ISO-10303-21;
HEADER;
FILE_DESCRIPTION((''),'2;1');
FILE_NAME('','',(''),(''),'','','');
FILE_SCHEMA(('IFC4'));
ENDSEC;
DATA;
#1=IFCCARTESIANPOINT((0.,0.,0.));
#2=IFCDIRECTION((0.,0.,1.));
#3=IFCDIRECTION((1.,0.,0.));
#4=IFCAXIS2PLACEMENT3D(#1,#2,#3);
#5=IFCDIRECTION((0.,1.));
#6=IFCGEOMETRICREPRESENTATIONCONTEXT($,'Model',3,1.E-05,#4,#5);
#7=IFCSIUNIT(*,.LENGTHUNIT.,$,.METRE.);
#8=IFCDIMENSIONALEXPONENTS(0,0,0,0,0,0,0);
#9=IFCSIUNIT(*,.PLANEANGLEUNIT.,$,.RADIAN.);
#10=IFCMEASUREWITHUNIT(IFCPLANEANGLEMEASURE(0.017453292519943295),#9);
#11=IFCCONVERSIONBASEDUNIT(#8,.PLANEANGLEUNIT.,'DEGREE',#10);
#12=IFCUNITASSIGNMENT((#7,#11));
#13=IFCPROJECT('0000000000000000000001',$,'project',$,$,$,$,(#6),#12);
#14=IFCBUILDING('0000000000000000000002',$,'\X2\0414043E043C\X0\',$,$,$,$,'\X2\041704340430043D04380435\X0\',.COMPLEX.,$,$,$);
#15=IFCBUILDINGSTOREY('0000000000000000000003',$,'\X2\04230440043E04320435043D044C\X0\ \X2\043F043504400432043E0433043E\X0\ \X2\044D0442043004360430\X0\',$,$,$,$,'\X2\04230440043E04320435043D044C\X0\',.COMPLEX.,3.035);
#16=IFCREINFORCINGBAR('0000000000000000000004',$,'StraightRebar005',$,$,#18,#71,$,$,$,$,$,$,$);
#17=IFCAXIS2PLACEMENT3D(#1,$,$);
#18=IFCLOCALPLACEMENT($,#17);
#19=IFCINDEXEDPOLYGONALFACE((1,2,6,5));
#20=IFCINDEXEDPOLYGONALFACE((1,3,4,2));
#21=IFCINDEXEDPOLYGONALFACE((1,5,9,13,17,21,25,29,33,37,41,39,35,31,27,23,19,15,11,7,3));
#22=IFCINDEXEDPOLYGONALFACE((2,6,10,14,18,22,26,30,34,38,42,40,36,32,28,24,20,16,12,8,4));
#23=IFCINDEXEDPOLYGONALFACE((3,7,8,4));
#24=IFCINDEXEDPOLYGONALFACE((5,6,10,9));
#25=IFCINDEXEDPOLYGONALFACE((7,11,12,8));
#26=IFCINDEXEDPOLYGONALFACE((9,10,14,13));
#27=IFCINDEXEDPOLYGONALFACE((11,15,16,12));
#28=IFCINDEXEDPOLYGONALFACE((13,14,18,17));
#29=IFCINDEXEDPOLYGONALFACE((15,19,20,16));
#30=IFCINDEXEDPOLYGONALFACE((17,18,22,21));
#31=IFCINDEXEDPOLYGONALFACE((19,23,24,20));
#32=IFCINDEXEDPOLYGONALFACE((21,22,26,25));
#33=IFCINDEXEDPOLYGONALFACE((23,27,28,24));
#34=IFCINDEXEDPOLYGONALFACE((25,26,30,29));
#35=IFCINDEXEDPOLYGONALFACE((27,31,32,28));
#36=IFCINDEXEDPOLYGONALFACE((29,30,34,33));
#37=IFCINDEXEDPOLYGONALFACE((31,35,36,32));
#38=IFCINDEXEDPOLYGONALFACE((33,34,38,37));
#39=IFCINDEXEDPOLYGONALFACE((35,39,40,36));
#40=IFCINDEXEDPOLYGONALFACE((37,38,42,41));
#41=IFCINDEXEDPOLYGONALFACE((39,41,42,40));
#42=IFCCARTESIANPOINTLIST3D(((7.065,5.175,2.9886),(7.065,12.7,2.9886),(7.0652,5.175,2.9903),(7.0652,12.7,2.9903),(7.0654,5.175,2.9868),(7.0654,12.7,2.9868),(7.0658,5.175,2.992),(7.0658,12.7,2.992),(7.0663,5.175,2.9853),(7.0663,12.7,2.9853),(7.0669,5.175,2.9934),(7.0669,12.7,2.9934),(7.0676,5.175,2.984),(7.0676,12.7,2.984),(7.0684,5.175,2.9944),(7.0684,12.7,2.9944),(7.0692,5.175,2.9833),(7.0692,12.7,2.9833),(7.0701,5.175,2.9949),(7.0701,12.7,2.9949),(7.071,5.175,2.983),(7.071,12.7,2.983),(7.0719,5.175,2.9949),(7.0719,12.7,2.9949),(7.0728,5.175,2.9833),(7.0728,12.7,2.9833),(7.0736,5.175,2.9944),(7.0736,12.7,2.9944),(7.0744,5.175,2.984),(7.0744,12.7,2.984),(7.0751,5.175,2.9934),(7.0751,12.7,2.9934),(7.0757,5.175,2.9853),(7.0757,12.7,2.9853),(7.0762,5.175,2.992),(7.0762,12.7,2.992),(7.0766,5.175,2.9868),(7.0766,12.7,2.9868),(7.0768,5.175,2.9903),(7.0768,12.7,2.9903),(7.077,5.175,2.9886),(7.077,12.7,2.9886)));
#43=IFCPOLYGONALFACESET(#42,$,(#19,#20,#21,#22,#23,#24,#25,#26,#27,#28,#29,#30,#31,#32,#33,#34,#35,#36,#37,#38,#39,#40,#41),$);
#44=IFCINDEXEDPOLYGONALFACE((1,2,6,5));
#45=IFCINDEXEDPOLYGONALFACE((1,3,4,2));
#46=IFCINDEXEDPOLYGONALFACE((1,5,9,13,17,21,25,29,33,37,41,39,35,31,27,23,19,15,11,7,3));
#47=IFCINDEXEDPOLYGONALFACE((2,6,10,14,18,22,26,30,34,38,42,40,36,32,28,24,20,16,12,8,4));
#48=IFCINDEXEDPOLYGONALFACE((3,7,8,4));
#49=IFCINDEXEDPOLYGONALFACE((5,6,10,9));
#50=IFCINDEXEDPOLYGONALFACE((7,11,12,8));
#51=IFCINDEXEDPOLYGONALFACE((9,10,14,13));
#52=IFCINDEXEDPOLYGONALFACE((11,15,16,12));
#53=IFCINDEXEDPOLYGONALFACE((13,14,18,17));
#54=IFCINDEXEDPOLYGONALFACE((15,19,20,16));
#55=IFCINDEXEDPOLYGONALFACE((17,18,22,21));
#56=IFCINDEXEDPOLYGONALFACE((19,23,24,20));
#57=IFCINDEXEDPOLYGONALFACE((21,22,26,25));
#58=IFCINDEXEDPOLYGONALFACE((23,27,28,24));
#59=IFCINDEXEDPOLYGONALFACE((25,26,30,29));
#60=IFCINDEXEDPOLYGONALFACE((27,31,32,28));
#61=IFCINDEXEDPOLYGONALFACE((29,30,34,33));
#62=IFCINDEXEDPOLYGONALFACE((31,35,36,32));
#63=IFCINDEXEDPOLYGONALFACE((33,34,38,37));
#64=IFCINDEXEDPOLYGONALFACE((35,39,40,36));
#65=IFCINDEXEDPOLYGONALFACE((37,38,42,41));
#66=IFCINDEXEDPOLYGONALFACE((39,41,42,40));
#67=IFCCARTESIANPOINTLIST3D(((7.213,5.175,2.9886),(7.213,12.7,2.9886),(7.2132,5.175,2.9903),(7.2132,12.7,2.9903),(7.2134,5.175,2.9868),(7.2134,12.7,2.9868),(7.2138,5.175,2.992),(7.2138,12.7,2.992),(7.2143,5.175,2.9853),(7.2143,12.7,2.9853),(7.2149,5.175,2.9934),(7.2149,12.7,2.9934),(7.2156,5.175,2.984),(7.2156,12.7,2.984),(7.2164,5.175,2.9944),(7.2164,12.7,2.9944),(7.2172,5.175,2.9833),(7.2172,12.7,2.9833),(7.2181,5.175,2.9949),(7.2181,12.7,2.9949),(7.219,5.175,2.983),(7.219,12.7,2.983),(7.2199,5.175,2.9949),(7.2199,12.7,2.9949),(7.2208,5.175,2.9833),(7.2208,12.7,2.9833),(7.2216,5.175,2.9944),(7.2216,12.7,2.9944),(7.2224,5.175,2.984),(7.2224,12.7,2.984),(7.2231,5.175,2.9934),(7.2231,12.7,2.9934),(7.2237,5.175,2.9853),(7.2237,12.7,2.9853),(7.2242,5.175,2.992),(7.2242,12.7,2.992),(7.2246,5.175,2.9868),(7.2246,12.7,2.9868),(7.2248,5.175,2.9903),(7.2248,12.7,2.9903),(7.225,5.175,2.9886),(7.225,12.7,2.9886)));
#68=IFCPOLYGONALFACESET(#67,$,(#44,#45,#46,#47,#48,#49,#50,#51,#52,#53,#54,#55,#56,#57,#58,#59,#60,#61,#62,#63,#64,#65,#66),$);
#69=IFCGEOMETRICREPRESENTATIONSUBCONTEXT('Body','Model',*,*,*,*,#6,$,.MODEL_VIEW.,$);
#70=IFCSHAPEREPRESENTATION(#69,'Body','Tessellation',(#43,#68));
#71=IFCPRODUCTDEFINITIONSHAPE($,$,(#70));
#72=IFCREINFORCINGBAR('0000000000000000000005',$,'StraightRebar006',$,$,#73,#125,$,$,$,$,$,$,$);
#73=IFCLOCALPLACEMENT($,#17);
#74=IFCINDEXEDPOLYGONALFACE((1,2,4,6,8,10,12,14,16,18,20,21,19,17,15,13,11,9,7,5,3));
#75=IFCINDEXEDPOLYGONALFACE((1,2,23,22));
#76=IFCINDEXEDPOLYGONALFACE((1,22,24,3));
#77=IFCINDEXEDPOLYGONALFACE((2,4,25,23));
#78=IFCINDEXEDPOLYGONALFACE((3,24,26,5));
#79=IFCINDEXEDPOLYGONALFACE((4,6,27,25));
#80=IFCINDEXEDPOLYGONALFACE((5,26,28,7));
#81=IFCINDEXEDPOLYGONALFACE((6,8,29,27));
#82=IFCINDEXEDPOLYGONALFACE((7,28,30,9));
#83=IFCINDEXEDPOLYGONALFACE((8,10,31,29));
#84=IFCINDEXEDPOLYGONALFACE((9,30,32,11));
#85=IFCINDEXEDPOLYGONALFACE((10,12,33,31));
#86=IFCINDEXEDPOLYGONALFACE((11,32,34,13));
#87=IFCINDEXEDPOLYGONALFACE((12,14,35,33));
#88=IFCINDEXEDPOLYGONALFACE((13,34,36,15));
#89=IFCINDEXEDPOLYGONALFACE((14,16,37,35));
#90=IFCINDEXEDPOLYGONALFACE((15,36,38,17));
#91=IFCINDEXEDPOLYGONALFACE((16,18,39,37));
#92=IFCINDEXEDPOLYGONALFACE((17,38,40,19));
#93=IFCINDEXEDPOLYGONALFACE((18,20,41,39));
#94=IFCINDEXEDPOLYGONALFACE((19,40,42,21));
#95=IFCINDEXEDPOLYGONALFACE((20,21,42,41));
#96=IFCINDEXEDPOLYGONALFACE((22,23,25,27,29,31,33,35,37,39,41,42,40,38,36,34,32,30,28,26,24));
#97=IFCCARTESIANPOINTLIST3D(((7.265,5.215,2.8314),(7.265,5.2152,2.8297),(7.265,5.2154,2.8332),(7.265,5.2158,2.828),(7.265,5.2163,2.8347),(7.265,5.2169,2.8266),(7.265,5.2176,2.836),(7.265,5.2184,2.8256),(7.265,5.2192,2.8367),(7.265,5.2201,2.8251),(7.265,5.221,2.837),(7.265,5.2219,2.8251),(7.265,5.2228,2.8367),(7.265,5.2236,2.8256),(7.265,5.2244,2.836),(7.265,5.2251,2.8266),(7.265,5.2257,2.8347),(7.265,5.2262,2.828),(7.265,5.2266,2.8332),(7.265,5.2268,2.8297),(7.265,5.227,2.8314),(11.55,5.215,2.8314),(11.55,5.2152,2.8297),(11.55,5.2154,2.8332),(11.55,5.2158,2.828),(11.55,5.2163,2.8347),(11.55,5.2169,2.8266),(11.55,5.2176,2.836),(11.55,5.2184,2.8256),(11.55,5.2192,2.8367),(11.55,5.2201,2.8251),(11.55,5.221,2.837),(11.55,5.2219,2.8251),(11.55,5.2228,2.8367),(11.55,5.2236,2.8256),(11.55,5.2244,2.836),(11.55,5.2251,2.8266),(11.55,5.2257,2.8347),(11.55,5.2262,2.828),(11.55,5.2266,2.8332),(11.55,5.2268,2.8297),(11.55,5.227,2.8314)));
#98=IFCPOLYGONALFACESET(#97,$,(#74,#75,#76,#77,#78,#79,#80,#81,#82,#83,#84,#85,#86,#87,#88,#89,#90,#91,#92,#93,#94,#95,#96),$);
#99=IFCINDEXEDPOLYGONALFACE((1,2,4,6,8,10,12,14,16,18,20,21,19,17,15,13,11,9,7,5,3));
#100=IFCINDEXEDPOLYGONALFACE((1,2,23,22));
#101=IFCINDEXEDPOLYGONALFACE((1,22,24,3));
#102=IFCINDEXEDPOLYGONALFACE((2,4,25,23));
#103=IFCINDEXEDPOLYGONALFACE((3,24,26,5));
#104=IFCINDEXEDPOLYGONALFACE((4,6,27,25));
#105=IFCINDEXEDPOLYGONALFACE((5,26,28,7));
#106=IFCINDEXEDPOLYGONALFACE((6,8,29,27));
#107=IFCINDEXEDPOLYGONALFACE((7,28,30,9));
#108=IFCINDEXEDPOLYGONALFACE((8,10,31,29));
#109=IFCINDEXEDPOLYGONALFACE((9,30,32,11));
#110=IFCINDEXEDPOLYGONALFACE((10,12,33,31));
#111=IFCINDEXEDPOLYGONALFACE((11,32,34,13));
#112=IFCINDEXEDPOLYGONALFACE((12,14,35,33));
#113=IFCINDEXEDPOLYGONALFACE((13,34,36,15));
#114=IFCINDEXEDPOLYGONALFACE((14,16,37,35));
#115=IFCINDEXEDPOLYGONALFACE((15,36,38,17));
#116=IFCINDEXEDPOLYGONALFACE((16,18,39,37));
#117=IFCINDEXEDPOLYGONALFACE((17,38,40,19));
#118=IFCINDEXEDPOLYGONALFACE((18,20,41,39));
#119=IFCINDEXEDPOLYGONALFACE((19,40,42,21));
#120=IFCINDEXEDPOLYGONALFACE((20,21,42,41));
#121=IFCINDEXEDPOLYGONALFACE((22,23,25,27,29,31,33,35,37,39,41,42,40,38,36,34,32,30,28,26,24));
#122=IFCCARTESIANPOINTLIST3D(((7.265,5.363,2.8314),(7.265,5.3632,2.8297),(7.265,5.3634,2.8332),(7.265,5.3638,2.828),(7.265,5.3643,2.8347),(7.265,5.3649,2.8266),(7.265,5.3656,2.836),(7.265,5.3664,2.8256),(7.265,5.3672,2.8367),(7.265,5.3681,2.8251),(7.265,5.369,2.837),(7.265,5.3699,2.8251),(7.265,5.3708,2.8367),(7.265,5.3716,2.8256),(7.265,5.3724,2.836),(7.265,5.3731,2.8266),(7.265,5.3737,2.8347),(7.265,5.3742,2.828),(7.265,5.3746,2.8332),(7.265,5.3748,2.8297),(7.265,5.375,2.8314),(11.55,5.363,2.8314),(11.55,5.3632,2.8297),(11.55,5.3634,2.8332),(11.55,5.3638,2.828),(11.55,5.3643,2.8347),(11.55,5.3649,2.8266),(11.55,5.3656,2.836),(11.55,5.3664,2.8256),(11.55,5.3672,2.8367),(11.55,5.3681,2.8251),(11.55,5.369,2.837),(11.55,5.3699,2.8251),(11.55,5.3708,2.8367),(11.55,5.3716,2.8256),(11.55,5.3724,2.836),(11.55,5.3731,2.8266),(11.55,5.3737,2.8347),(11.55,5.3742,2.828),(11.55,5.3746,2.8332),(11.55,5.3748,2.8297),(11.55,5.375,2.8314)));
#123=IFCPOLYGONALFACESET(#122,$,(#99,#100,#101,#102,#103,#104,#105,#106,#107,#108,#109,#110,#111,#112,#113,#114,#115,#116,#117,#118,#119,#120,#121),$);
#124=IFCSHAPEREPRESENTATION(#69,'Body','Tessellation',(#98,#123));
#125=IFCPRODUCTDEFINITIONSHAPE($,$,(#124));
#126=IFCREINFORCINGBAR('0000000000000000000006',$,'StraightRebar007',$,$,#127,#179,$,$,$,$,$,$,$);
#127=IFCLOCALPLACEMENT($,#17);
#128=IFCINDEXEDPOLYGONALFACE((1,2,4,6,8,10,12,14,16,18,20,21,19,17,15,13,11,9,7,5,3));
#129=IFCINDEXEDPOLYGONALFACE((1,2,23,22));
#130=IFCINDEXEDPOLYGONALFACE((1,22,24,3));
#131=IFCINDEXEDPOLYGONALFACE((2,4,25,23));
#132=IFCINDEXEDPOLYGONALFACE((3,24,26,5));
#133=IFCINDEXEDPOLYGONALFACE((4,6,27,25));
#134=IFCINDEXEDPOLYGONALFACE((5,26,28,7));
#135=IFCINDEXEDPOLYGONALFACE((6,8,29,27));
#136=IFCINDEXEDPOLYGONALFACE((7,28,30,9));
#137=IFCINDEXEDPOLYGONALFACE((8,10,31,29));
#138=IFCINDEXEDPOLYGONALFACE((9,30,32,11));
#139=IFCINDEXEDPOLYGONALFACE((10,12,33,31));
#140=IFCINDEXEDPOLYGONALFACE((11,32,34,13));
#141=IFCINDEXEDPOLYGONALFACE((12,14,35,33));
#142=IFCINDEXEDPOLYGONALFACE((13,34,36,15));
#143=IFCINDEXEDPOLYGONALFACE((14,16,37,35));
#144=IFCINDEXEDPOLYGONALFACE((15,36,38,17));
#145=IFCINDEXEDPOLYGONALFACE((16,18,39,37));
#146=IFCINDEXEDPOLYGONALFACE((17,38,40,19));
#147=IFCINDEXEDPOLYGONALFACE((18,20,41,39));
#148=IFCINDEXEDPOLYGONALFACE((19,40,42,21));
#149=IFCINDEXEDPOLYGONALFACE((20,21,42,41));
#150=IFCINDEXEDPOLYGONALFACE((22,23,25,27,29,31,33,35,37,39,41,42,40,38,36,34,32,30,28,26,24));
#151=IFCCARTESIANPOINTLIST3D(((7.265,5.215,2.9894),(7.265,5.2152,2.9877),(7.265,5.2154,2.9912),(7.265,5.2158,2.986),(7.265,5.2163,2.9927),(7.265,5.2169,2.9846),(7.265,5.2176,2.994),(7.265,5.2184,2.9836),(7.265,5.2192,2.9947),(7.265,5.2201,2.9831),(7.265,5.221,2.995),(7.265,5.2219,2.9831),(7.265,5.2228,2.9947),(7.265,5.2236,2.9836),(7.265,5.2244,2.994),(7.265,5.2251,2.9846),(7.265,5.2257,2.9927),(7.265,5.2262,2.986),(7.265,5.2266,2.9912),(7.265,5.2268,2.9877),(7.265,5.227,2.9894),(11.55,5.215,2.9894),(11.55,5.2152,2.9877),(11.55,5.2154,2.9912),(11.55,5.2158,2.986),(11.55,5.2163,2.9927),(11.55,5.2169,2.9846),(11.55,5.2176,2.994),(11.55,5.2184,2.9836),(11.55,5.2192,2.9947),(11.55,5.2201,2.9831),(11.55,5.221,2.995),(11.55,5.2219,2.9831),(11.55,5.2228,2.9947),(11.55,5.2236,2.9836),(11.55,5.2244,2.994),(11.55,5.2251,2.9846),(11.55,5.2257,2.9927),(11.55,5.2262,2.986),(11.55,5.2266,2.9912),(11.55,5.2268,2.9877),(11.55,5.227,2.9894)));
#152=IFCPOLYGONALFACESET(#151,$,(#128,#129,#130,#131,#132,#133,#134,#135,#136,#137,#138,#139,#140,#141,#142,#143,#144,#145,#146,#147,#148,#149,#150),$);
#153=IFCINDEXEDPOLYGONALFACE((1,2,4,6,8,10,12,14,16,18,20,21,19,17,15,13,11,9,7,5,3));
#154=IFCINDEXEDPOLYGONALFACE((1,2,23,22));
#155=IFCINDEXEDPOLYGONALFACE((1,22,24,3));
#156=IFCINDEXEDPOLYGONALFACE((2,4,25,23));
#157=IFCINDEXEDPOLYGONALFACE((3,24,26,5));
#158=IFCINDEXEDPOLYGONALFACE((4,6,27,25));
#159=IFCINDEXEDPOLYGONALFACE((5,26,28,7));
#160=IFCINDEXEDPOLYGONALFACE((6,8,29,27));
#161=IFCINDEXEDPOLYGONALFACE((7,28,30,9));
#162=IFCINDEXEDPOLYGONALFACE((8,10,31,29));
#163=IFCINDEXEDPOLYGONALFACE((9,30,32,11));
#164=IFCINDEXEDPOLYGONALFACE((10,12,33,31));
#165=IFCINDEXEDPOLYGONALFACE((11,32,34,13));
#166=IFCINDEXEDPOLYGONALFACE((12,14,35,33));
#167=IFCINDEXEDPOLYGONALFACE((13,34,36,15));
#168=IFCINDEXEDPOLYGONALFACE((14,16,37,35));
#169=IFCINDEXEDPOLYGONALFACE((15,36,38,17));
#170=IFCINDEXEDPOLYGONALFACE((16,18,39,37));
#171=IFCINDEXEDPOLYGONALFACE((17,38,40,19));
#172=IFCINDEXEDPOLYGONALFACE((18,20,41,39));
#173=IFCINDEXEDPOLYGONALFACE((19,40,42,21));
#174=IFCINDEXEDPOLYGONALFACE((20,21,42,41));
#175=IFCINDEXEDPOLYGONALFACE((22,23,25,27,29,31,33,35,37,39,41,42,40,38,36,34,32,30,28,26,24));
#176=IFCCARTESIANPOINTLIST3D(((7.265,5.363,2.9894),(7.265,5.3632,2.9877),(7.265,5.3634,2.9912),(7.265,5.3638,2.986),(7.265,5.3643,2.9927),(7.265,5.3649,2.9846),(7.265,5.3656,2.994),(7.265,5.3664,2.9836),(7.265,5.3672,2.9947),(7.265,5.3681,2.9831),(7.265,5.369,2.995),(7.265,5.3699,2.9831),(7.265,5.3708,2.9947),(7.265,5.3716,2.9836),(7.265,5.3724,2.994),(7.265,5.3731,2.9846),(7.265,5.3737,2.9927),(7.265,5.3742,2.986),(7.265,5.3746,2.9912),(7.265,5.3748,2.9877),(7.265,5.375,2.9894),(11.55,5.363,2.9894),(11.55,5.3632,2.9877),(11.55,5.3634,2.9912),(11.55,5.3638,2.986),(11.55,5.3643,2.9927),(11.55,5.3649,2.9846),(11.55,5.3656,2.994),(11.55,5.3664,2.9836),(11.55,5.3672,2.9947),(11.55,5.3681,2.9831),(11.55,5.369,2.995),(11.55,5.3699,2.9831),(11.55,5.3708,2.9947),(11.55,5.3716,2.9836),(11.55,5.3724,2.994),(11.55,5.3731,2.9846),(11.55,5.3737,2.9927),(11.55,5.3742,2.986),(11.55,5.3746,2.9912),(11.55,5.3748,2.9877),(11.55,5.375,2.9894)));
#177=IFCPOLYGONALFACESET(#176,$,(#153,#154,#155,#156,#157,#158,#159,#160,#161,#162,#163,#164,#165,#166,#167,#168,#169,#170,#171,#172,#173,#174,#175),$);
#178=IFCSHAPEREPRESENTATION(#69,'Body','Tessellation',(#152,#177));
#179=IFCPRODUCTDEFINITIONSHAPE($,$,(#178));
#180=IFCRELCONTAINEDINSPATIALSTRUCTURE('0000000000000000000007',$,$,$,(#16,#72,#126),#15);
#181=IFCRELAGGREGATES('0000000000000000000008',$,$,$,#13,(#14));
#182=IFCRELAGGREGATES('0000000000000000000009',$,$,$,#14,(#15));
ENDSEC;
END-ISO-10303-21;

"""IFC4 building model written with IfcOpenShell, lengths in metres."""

from ifc_helpers import new_model, entity, si_unit, converted_unit, direction, origin_with_axes, place, context, subcontext, project, spatial, element, save


model = new_model("IFC4")

# Units and contexts
model_context = context("Model", 3, precision=1e-05, world=origin_with_axes(), true_north=direction((0.0, 1.0)))
body_context = subcontext(model_context, "Body", "Model", "MODEL_VIEW")
ifc_project = project(units=[si_unit("LENGTHUNIT", "METRE"), converted_unit("PLANEANGLEUNIT", "DEGREE", entity("IfcPlaneAngleMeasure", 0.017453292519943295), si_unit("PLANEANGLEUNIT", "RADIAN"), dimensions=[0, 0, 0, 0, 0, 0, 0])], contexts=[model_context])

# Building, storey
building = spatial("IfcBuilding", under=ifc_project, Name="Дом", LongName="Здание", CompositionType="COMPLEX")
storey = spatial("IfcBuildingStorey", under=building, Name="Уровень первого этажа", LongName="Уровень", CompositionType="COMPLEX", Elevation=3.035)

# Shared definitions
placement = place(None, origin_with_axes())

# Reinforcing bars
element("IfcReinforcingBar", 1, at=placement, inside=storey, Name="StraightRebar005", context=body_context, shape_type="SweptSolid", body=[
    entity("IfcSweptDiskSolid", entity("IfcCompositeCurve", [entity("IfcCompositeCurveSegment", "CONTINUOUS", True, entity("IfcPolyline", [entity("IfcCartesianPoint", [7.071, 12.7, 2.989]), entity("IfcCartesianPoint", [7.071, 5.175, 2.989])]))], False), 0.006),
    entity("IfcSweptDiskSolid", entity("IfcCompositeCurve", [entity("IfcCompositeCurveSegment", "CONTINUOUS", True, entity("IfcPolyline", [entity("IfcCartesianPoint", [7.219, 12.7, 2.989]), entity("IfcCartesianPoint", [7.219, 5.175, 2.989])]))], False), 0.006),
])
element("IfcReinforcingBar", 2, at=placement, inside=storey, Name="StraightRebar006", context=body_context, shape_type="SweptSolid", body=[
    entity("IfcSweptDiskSolid", entity("IfcCompositeCurve", [entity("IfcCompositeCurveSegment", "CONTINUOUS", True, entity("IfcPolyline", [entity("IfcCartesianPoint", [7.265, 5.221, 2.831]), entity("IfcCartesianPoint", [11.55, 5.221, 2.831])]))], False), 0.006),
    entity("IfcSweptDiskSolid", entity("IfcCompositeCurve", [entity("IfcCompositeCurveSegment", "CONTINUOUS", True, entity("IfcPolyline", [entity("IfcCartesianPoint", [7.265, 5.369, 2.831]), entity("IfcCartesianPoint", [11.55, 5.369, 2.831])]))], False), 0.006),
])
element("IfcReinforcingBar", 3, at=placement, inside=storey, Name="StraightRebar007", context=body_context, shape_type="SweptSolid", body=[
    entity("IfcSweptDiskSolid", entity("IfcCompositeCurve", [entity("IfcCompositeCurveSegment", "CONTINUOUS", True, entity("IfcPolyline", [entity("IfcCartesianPoint", [7.265, 5.221, 2.989]), entity("IfcCartesianPoint", [11.55, 5.221, 2.989])]))], False), 0.006),
    entity("IfcSweptDiskSolid", entity("IfcCompositeCurve", [entity("IfcCompositeCurveSegment", "CONTINUOUS", True, entity("IfcPolyline", [entity("IfcCartesianPoint", [7.265, 5.369, 2.989]), entity("IfcCartesianPoint", [11.55, 5.369, 2.989])]))], False), 0.006),
])

save(model, "model.ifc")
